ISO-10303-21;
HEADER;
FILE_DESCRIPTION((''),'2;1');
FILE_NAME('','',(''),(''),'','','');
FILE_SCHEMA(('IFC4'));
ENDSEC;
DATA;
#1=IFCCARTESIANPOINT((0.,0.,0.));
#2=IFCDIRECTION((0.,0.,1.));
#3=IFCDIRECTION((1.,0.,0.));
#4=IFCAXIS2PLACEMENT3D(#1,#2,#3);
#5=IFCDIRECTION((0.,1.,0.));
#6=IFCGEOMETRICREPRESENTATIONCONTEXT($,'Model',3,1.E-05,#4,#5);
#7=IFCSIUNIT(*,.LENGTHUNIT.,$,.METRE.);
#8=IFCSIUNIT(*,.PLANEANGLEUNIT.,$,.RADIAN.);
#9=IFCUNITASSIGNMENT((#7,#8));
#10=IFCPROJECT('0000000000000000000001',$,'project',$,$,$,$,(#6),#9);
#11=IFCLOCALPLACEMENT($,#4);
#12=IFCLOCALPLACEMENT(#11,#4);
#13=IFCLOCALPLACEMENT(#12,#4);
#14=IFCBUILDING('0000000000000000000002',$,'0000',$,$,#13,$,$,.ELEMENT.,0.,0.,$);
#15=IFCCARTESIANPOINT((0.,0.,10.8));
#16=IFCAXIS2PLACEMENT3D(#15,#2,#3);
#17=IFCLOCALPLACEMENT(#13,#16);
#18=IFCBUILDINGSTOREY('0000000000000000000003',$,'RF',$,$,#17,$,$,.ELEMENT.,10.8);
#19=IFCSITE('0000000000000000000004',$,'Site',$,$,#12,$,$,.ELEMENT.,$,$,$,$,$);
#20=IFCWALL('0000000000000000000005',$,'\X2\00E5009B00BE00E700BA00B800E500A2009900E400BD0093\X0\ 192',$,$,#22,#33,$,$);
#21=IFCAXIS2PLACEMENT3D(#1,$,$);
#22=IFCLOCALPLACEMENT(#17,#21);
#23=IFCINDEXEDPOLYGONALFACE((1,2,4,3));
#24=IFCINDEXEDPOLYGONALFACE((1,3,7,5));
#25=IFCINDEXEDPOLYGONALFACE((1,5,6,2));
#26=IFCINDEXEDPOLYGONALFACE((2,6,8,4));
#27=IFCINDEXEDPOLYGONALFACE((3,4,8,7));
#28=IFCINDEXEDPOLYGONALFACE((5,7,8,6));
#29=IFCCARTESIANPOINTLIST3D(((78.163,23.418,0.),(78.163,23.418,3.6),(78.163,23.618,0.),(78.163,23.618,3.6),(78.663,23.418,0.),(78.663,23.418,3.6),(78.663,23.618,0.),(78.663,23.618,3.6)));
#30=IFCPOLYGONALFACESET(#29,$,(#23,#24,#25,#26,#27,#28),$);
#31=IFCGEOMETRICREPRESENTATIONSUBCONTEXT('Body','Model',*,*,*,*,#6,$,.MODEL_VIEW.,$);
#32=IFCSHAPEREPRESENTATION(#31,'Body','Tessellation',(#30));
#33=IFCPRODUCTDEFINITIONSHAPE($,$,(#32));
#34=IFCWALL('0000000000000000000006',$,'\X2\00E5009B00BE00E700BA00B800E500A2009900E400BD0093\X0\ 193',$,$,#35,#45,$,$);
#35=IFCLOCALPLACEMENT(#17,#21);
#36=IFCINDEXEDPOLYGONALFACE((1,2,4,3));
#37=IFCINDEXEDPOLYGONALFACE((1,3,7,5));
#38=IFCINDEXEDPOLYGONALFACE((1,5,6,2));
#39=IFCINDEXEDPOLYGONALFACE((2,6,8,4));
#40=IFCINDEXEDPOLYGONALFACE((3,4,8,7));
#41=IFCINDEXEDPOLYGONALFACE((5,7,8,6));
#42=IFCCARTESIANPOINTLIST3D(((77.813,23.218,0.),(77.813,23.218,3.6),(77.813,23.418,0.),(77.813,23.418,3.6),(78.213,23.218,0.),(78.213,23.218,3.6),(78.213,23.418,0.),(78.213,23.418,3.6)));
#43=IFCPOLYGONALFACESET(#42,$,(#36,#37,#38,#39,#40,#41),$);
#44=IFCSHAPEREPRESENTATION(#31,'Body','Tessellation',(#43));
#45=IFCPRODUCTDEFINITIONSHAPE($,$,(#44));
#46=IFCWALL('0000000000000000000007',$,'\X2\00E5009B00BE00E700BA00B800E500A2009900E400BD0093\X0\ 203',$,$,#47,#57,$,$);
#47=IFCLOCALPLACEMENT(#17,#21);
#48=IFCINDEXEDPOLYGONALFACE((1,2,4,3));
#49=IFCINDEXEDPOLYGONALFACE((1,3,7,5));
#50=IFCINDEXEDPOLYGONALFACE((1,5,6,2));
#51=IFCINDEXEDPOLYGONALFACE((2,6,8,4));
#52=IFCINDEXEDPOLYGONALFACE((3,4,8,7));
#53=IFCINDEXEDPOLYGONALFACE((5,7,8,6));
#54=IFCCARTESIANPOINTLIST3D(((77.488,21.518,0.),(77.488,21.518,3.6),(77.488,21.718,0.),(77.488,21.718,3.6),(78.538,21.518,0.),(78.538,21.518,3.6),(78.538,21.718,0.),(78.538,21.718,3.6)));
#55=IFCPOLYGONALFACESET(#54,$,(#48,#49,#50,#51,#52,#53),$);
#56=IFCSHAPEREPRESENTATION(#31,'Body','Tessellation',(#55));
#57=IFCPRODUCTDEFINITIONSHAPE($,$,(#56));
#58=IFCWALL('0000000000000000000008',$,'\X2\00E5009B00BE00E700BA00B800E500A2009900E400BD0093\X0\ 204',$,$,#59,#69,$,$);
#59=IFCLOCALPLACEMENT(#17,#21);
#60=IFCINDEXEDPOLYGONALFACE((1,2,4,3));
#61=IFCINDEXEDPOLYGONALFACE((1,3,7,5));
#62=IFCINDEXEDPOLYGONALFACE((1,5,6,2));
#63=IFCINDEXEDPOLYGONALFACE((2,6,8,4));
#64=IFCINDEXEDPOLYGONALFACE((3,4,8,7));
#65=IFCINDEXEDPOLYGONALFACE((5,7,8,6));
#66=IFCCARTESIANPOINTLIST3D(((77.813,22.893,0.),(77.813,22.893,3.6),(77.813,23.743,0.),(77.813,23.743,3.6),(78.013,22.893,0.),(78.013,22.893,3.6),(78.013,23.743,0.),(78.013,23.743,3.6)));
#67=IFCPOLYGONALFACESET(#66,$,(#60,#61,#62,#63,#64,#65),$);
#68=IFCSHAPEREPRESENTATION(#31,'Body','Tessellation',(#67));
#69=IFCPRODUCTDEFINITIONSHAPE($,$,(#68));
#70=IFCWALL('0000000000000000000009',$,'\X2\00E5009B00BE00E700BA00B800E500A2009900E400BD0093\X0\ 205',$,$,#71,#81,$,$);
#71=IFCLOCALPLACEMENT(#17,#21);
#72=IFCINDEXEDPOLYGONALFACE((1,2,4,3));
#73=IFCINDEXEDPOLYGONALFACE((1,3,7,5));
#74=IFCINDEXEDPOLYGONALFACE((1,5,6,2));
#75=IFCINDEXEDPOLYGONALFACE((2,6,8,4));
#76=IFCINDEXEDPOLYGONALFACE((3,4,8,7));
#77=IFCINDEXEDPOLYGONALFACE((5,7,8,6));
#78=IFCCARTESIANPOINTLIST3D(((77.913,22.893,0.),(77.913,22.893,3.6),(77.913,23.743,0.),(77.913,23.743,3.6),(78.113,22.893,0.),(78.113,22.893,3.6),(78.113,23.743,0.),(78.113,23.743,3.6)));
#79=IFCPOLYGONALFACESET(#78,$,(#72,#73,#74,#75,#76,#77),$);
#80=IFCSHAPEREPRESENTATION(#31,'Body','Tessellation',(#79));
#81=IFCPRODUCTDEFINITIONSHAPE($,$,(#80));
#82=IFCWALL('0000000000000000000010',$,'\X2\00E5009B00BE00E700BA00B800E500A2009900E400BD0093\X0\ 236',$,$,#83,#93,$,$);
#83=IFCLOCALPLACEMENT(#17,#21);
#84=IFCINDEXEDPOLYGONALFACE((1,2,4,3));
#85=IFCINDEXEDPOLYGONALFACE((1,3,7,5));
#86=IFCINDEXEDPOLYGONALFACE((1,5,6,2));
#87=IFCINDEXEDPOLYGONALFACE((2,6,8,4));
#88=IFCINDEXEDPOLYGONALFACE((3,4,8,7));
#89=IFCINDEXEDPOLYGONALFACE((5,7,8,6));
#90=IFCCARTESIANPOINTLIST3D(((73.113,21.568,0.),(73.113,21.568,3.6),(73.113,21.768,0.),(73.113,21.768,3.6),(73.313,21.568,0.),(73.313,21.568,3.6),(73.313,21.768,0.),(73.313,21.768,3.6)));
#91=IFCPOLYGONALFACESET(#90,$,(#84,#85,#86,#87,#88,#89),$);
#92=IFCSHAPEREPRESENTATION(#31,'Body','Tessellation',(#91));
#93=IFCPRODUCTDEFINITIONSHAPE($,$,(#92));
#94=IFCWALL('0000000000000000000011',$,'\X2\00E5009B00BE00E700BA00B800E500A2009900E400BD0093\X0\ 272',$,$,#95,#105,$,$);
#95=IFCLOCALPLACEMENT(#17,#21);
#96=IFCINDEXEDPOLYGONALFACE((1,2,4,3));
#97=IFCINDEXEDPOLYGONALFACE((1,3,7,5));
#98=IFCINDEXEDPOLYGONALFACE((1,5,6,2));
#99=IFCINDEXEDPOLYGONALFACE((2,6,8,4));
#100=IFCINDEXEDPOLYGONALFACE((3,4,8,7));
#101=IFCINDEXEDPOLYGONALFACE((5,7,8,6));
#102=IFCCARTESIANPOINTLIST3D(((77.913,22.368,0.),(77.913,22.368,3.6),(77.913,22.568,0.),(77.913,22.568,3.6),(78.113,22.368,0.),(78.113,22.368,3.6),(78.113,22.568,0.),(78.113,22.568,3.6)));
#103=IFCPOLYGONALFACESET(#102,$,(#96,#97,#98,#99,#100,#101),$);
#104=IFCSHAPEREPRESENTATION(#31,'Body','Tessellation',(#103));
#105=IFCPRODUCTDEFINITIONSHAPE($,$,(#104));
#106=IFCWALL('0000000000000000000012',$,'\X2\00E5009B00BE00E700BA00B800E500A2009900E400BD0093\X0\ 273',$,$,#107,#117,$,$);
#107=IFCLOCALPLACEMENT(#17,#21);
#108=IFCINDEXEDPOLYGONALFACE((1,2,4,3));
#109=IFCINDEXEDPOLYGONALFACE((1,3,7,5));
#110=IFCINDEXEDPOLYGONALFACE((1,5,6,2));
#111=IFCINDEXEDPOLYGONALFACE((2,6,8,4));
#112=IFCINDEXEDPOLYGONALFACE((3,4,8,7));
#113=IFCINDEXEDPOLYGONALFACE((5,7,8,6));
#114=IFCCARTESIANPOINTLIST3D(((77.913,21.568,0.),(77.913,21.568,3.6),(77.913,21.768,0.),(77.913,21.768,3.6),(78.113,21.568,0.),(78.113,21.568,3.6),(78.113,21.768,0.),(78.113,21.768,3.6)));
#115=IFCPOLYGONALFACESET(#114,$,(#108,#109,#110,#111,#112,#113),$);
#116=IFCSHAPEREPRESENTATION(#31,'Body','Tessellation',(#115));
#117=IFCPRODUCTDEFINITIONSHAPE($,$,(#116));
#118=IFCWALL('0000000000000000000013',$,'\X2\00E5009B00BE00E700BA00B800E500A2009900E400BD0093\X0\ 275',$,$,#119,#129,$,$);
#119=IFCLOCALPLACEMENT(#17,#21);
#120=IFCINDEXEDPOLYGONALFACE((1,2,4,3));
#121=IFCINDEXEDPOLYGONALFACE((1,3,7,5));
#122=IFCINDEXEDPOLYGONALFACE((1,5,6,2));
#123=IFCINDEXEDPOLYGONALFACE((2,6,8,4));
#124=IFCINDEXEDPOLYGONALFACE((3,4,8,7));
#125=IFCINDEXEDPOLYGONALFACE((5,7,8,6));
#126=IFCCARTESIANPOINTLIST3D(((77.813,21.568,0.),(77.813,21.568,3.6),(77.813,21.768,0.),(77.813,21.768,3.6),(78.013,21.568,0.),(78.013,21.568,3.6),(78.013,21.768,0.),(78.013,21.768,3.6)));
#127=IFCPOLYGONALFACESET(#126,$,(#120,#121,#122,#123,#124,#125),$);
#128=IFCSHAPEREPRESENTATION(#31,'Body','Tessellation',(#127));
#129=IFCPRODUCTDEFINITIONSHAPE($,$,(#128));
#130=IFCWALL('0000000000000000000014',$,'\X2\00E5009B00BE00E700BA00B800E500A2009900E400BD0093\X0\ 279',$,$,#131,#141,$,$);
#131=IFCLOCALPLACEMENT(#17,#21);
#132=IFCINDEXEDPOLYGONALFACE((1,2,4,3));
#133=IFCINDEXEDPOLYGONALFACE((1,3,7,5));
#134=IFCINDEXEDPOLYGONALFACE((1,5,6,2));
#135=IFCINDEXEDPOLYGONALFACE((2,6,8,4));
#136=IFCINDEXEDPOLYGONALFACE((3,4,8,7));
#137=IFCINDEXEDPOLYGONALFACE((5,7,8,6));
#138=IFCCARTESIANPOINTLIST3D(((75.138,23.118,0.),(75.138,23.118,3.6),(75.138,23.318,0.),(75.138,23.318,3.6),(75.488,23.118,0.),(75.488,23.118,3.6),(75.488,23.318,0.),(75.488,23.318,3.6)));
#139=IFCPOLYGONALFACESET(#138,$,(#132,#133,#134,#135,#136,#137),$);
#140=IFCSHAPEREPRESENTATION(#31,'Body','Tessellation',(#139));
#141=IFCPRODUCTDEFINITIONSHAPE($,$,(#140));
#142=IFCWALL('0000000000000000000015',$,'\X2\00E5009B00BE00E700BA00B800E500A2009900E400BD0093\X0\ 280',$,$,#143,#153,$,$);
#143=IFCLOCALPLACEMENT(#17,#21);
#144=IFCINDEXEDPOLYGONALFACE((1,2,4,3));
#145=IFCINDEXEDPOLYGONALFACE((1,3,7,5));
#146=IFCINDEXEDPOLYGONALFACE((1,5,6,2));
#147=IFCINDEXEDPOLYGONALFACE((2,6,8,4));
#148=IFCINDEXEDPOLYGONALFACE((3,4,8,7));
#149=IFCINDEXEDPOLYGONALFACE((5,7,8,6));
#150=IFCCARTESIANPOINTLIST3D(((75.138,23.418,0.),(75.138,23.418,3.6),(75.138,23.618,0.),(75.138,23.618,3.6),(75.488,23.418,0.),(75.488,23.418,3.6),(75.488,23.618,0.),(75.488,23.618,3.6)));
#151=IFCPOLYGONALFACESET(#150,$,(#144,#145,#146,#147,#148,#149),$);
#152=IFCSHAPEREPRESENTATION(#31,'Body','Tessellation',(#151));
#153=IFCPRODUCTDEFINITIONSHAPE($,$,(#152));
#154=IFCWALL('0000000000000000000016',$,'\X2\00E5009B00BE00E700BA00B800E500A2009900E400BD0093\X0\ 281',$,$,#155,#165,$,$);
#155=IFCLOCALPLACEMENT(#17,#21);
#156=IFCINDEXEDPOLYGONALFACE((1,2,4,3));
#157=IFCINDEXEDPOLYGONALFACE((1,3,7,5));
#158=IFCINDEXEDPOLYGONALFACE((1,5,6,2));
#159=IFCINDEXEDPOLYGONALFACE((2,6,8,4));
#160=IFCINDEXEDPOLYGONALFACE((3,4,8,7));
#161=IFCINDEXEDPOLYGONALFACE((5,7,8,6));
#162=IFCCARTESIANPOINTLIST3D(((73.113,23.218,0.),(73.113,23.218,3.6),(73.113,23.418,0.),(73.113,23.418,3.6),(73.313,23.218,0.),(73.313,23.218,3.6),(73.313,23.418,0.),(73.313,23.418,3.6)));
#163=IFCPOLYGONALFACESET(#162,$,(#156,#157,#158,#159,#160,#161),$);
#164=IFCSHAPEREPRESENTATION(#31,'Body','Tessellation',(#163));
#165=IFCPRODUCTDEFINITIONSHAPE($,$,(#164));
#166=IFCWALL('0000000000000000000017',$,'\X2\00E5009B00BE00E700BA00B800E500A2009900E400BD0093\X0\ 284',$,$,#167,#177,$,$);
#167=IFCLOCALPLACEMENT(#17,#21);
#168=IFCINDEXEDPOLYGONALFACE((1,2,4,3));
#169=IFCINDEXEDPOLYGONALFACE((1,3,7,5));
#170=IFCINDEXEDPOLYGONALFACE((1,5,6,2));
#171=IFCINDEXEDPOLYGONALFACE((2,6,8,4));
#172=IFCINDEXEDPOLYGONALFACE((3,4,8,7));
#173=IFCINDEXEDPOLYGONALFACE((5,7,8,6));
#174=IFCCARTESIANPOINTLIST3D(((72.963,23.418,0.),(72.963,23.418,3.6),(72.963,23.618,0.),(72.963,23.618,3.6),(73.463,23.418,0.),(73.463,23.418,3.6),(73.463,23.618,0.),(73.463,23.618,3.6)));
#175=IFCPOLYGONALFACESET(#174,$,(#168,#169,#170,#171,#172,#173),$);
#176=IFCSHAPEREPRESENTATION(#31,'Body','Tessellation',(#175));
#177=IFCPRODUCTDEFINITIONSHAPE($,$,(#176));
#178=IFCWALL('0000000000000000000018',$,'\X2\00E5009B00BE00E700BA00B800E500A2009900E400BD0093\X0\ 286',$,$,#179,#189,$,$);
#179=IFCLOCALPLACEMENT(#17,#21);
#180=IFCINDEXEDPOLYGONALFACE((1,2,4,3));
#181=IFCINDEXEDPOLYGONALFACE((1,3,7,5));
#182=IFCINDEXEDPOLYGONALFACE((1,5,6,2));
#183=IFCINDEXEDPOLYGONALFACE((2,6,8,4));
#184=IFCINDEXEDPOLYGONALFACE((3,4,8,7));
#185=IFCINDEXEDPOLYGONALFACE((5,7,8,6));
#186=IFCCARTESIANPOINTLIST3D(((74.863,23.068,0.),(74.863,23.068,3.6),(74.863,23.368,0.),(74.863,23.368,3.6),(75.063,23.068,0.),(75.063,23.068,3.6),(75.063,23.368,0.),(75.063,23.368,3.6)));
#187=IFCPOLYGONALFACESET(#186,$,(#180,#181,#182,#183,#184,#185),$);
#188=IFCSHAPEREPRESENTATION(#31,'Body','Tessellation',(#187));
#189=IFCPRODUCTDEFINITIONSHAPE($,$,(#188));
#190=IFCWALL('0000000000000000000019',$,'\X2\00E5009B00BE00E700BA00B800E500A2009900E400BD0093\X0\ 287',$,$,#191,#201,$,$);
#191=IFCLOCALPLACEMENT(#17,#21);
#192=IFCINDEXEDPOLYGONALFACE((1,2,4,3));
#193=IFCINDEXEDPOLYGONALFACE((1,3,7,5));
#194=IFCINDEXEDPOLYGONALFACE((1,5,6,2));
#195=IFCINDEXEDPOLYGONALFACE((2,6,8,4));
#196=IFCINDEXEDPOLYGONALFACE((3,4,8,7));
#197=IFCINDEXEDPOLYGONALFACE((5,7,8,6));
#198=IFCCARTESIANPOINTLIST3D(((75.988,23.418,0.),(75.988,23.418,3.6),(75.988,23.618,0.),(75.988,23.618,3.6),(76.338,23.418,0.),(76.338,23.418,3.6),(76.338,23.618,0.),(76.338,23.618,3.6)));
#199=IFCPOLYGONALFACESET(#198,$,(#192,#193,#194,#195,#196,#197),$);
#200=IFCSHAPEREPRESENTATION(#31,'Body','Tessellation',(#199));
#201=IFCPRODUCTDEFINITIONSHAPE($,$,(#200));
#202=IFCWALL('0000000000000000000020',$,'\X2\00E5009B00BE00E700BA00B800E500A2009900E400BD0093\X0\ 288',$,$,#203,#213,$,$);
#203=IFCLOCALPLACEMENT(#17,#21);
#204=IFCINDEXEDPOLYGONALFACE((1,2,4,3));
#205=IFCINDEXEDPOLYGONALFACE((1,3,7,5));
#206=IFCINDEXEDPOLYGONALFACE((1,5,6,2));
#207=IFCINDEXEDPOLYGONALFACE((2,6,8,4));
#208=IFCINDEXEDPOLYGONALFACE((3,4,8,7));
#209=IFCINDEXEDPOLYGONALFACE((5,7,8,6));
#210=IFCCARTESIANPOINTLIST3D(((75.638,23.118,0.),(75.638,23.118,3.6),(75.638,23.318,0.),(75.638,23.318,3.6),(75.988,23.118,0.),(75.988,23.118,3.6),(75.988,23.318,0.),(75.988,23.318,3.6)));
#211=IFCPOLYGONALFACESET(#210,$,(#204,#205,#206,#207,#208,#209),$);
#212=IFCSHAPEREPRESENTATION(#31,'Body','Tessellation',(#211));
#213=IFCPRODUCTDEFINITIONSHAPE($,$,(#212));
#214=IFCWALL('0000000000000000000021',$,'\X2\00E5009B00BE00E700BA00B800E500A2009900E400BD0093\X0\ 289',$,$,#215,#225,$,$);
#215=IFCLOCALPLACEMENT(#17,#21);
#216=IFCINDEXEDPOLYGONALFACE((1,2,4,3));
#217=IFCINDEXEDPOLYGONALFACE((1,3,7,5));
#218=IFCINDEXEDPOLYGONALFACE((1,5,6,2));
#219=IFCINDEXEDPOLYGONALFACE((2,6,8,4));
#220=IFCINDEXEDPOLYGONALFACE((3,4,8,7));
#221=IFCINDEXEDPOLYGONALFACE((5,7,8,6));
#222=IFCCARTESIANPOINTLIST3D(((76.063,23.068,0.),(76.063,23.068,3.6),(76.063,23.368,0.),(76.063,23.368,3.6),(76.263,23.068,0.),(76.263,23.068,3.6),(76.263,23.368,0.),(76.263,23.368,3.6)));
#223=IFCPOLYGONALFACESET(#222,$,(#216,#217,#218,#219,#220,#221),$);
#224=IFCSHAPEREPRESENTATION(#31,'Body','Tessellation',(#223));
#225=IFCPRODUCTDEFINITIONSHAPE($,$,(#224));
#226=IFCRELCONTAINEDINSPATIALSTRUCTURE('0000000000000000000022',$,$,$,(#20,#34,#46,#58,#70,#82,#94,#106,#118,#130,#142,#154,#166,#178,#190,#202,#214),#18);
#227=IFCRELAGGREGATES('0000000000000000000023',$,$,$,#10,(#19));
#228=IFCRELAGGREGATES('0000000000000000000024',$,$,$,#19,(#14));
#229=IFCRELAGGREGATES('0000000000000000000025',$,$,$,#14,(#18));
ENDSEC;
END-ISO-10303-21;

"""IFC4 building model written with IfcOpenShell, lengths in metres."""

from ifc_helpers import new_model, si_unit, direction, frame, frame_2d, origin_with_axes, place, context, subcontext, project, spatial, rectangle, extrude, element, save


model = new_model("IFC4")

# Units and contexts
model_context = context("Model", 3, precision=1e-05, world=origin_with_axes(), true_north=direction((0.0, 1.0, 0.0)))
body_context = subcontext(model_context, "Body", "Model", "MODEL_VIEW")
ifc_project = project(units=[si_unit("LENGTHUNIT", "METRE"), si_unit("PLANEANGLEUNIT", "RADIAN")], contexts=[model_context])

# Site, building, storey
placement = place(None, origin_with_axes())
site_placement = place(placement, origin_with_axes())
site = spatial("IfcSite", under=ifc_project, at=site_placement, Name="Site", CompositionType="ELEMENT")
building_placement = place(site_placement, origin_with_axes())
building = spatial("IfcBuilding", under=site, at=building_placement, Name="0000", CompositionType="ELEMENT", ElevationOfRefHeight=0.0, ElevationOfTerrain=0.0)
storey_placement = place(building_placement, frame((0.0, 0.0, 10.8), z_axis=(0.0, 0.0, 1.0), x_axis=(1.0, 0.0, 0.0)))
storey = spatial("IfcBuildingStorey", under=building, at=storey_placement, Name="RF", CompositionType="ELEMENT", Elevation=10.8)

# Walls
wall_1_placement = place(storey_placement, frame((78.413, 23.518, 0.0), z_axis=(0.0, 0.0, 1.0), x_axis=(-1.0, 0.0, 0.0)))
element("IfcWall", 1, at=wall_1_placement, inside=storey, Name="å\u009b¾çº¸å¢\u0099ä½\u0093 192", context=body_context, shape_type="SweptSolid", body=[
    extrude(rectangle(XDim=0.5, YDim=0.2, at=frame_2d((0.0, 0.0), x_axis=(1.0, 0.0, 0.0))), frame((0.0, 0.0, 0.0), z_axis=(0.0, 0.0, 1.0)), (0.0, 0.0, 1.0), 3.6),
])
wall_2_placement = place(storey_placement, frame((78.013, 23.318, 0.0), z_axis=(0.0, 0.0, 1.0), x_axis=(1.0, 0.0, 0.0)))
element("IfcWall", 2, at=wall_2_placement, inside=storey, Name="å\u009b¾çº¸å¢\u0099ä½\u0093 193", context=body_context, shape_type="SweptSolid", body=[
    extrude(rectangle(XDim=0.4, YDim=0.2, at=frame_2d((0.0, 0.0), x_axis=(1.0, 0.0, 0.0))), frame((0.0, 0.0, 0.0), z_axis=(0.0, 0.0, 1.0)), (0.0, 0.0, 1.0), 3.6),
])
wall_3_placement = place(storey_placement, frame((78.013, 21.618, 0.0), z_axis=(0.0, 0.0, 1.0), x_axis=(1.0, 0.0, 0.0)))
element("IfcWall", 3, at=wall_3_placement, inside=storey, Name="å\u009b¾çº¸å¢\u0099ä½\u0093 203", context=body_context, shape_type="SweptSolid", body=[
    extrude(rectangle(XDim=1.05, YDim=0.2, at=frame_2d((0.0, 0.0), x_axis=(1.0, 0.0, 0.0))), frame((0.0, 0.0, 0.0), z_axis=(0.0, 0.0, 1.0)), (0.0, 0.0, 1.0), 3.6),
])
for number, where, z_axis, x_axis, name in (
    (4, (77.913, 23.318, 0.0), (0.0, 0.0, 1.0), (0.0, -1.0, 0.0), "å\u009b¾çº¸å¢\u0099ä½\u0093 204"),
    (5, (78.013, 23.318, 0.0), (0.0, 0.0, 1.0), (0.0, -1.0, 0.0), "å\u009b¾çº¸å¢\u0099ä½\u0093 205"),
):
    element("IfcWall", number, at=place(storey_placement, frame(where, z_axis=z_axis, x_axis=x_axis)), inside=storey, Name=name, context=body_context, shape_type="SweptSolid", body=[
        extrude(rectangle(XDim=0.85, YDim=0.2, at=frame_2d((0.0, 0.0), x_axis=(1.0, 0.0, 0.0))), frame((0.0, 0.0, 0.0), z_axis=(0.0, 0.0, 1.0)), (0.0, 0.0, 1.0), 3.6),
    ])
for number, where, z_axis, x_axis, name in (
    (6, (73.213, 21.668, 0.0), (0.0, 0.0, 1.0), (0.0, -1.0, 0.0), "å\u009b¾çº¸å¢\u0099ä½\u0093 236"),
    (7, (78.013, 22.468, 0.0), (0.0, 0.0, 1.0), (-1.0, 0.0, 0.0), "å\u009b¾çº¸å¢\u0099ä½\u0093 272"),
    (8, (78.013, 21.668, 0.0), (0.0, 0.0, 1.0), (-1.0, 0.0, 0.0), "å\u009b¾çº¸å¢\u0099ä½\u0093 273"),
    (9, (77.913, 21.668, 0.0), (0.0, 0.0, 1.0), (0.0, -1.0, 0.0), "å\u009b¾çº¸å¢\u0099ä½\u0093 275"),
):
    element("IfcWall", number, at=place(storey_placement, frame(where, z_axis=z_axis, x_axis=x_axis)), inside=storey, Name=name, context=body_context, shape_type="SweptSolid", body=[
        extrude(rectangle(XDim=0.2, YDim=0.2, at=frame_2d((0.0, 0.0), x_axis=(1.0, 0.0, 0.0))), frame((0.0, 0.0, 0.0), z_axis=(0.0, 0.0, 1.0)), (0.0, 0.0, 1.0), 3.6),
    ])
for number, where, z_axis, x_axis, name in (
    (10, (75.313, 23.218, 0.0), (0.0, 0.0, 1.0), (-1.0, 0.0, 0.0), "å\u009b¾çº¸å¢\u0099ä½\u0093 279"),
    (11, (75.313, 23.518, 0.0), (0.0, 0.0, 1.0), (-1.0, 0.0, 0.0), "å\u009b¾çº¸å¢\u0099ä½\u0093 280"),
):
    element("IfcWall", number, at=place(storey_placement, frame(where, z_axis=z_axis, x_axis=x_axis)), inside=storey, Name=name, context=body_context, shape_type="SweptSolid", body=[
        extrude(rectangle(XDim=0.35, YDim=0.2, at=frame_2d((0.0, 0.0), x_axis=(1.0, 0.0, 0.0))), frame((0.0, 0.0, 0.0), z_axis=(0.0, 0.0, 1.0)), (0.0, 0.0, 1.0), 3.6),
    ])
wall_4_placement = place(storey_placement, frame((73.213, 23.318, 0.0), z_axis=(0.0, 0.0, 1.0), x_axis=(0.0, 1.0, 0.0)))
element("IfcWall", 12, at=wall_4_placement, inside=storey, Name="å\u009b¾çº¸å¢\u0099ä½\u0093 281", context=body_context, shape_type="SweptSolid", body=[
    extrude(rectangle(XDim=0.2, YDim=0.2, at=frame_2d((0.0, 0.0), x_axis=(1.0, 0.0, 0.0))), frame((0.0, 0.0, 0.0), z_axis=(0.0, 0.0, 1.0)), (0.0, 0.0, 1.0), 3.6),
])
wall_5_placement = place(storey_placement, frame((73.213, 23.518, 0.0), z_axis=(0.0, 0.0, 1.0), x_axis=(-1.0, 0.0, 0.0)))
element("IfcWall", 13, at=wall_5_placement, inside=storey, Name="å\u009b¾çº¸å¢\u0099ä½\u0093 284", context=body_context, shape_type="SweptSolid", body=[
    extrude(rectangle(XDim=0.5, YDim=0.2, at=frame_2d((0.0, 0.0), x_axis=(1.0, 0.0, 0.0))), frame((0.0, 0.0, 0.0), z_axis=(0.0, 0.0, 1.0)), (0.0, 0.0, 1.0), 3.6),
])
wall_6_placement = place(storey_placement, frame((74.963, 23.218, 0.0), z_axis=(0.0, 0.0, 1.0), x_axis=(0.0, 1.0, 0.0)))
element("IfcWall", 14, at=wall_6_placement, inside=storey, Name="å\u009b¾çº¸å¢\u0099ä½\u0093 286", context=body_context, shape_type="SweptSolid", body=[
    extrude(rectangle(XDim=0.3, YDim=0.2, at=frame_2d((0.0, 0.0), x_axis=(1.0, 0.0, 0.0))), frame((0.0, 0.0, 0.0), z_axis=(0.0, 0.0, 1.0)), (0.0, 0.0, 1.0), 3.6),
])
for number, where, z_axis, x_axis, name in (
    (15, (76.163, 23.518, 0.0), (0.0, 0.0, 1.0), (-1.0, 0.0, 0.0), "å\u009b¾çº¸å¢\u0099ä½\u0093 287"),
    (16, (75.813, 23.218, 0.0), (0.0, 0.0, 1.0), (1.0, 0.0, 0.0), "å\u009b¾çº¸å¢\u0099ä½\u0093 288"),
):
    element("IfcWall", number, at=place(storey_placement, frame(where, z_axis=z_axis, x_axis=x_axis)), inside=storey, Name=name, context=body_context, shape_type="SweptSolid", body=[
        extrude(rectangle(XDim=0.35, YDim=0.2, at=frame_2d((0.0, 0.0), x_axis=(1.0, 0.0, 0.0))), frame((0.0, 0.0, 0.0), z_axis=(0.0, 0.0, 1.0)), (0.0, 0.0, 1.0), 3.6),
    ])
wall_7_placement = place(storey_placement, frame((76.163, 23.218, 0.0), z_axis=(0.0, 0.0, 1.0), x_axis=(0.0, 1.0, 0.0)))
element("IfcWall", 17, at=wall_7_placement, inside=storey, Name="å\u009b¾çº¸å¢\u0099ä½\u0093 289", context=body_context, shape_type="SweptSolid", body=[
    extrude(rectangle(XDim=0.3, YDim=0.2, at=frame_2d((0.0, 0.0), x_axis=(1.0, 0.0, 0.0))), frame((0.0, 0.0, 0.0), z_axis=(0.0, 0.0, 1.0)), (0.0, 0.0, 1.0), 3.6),
])

save(model, "model.ifc")
